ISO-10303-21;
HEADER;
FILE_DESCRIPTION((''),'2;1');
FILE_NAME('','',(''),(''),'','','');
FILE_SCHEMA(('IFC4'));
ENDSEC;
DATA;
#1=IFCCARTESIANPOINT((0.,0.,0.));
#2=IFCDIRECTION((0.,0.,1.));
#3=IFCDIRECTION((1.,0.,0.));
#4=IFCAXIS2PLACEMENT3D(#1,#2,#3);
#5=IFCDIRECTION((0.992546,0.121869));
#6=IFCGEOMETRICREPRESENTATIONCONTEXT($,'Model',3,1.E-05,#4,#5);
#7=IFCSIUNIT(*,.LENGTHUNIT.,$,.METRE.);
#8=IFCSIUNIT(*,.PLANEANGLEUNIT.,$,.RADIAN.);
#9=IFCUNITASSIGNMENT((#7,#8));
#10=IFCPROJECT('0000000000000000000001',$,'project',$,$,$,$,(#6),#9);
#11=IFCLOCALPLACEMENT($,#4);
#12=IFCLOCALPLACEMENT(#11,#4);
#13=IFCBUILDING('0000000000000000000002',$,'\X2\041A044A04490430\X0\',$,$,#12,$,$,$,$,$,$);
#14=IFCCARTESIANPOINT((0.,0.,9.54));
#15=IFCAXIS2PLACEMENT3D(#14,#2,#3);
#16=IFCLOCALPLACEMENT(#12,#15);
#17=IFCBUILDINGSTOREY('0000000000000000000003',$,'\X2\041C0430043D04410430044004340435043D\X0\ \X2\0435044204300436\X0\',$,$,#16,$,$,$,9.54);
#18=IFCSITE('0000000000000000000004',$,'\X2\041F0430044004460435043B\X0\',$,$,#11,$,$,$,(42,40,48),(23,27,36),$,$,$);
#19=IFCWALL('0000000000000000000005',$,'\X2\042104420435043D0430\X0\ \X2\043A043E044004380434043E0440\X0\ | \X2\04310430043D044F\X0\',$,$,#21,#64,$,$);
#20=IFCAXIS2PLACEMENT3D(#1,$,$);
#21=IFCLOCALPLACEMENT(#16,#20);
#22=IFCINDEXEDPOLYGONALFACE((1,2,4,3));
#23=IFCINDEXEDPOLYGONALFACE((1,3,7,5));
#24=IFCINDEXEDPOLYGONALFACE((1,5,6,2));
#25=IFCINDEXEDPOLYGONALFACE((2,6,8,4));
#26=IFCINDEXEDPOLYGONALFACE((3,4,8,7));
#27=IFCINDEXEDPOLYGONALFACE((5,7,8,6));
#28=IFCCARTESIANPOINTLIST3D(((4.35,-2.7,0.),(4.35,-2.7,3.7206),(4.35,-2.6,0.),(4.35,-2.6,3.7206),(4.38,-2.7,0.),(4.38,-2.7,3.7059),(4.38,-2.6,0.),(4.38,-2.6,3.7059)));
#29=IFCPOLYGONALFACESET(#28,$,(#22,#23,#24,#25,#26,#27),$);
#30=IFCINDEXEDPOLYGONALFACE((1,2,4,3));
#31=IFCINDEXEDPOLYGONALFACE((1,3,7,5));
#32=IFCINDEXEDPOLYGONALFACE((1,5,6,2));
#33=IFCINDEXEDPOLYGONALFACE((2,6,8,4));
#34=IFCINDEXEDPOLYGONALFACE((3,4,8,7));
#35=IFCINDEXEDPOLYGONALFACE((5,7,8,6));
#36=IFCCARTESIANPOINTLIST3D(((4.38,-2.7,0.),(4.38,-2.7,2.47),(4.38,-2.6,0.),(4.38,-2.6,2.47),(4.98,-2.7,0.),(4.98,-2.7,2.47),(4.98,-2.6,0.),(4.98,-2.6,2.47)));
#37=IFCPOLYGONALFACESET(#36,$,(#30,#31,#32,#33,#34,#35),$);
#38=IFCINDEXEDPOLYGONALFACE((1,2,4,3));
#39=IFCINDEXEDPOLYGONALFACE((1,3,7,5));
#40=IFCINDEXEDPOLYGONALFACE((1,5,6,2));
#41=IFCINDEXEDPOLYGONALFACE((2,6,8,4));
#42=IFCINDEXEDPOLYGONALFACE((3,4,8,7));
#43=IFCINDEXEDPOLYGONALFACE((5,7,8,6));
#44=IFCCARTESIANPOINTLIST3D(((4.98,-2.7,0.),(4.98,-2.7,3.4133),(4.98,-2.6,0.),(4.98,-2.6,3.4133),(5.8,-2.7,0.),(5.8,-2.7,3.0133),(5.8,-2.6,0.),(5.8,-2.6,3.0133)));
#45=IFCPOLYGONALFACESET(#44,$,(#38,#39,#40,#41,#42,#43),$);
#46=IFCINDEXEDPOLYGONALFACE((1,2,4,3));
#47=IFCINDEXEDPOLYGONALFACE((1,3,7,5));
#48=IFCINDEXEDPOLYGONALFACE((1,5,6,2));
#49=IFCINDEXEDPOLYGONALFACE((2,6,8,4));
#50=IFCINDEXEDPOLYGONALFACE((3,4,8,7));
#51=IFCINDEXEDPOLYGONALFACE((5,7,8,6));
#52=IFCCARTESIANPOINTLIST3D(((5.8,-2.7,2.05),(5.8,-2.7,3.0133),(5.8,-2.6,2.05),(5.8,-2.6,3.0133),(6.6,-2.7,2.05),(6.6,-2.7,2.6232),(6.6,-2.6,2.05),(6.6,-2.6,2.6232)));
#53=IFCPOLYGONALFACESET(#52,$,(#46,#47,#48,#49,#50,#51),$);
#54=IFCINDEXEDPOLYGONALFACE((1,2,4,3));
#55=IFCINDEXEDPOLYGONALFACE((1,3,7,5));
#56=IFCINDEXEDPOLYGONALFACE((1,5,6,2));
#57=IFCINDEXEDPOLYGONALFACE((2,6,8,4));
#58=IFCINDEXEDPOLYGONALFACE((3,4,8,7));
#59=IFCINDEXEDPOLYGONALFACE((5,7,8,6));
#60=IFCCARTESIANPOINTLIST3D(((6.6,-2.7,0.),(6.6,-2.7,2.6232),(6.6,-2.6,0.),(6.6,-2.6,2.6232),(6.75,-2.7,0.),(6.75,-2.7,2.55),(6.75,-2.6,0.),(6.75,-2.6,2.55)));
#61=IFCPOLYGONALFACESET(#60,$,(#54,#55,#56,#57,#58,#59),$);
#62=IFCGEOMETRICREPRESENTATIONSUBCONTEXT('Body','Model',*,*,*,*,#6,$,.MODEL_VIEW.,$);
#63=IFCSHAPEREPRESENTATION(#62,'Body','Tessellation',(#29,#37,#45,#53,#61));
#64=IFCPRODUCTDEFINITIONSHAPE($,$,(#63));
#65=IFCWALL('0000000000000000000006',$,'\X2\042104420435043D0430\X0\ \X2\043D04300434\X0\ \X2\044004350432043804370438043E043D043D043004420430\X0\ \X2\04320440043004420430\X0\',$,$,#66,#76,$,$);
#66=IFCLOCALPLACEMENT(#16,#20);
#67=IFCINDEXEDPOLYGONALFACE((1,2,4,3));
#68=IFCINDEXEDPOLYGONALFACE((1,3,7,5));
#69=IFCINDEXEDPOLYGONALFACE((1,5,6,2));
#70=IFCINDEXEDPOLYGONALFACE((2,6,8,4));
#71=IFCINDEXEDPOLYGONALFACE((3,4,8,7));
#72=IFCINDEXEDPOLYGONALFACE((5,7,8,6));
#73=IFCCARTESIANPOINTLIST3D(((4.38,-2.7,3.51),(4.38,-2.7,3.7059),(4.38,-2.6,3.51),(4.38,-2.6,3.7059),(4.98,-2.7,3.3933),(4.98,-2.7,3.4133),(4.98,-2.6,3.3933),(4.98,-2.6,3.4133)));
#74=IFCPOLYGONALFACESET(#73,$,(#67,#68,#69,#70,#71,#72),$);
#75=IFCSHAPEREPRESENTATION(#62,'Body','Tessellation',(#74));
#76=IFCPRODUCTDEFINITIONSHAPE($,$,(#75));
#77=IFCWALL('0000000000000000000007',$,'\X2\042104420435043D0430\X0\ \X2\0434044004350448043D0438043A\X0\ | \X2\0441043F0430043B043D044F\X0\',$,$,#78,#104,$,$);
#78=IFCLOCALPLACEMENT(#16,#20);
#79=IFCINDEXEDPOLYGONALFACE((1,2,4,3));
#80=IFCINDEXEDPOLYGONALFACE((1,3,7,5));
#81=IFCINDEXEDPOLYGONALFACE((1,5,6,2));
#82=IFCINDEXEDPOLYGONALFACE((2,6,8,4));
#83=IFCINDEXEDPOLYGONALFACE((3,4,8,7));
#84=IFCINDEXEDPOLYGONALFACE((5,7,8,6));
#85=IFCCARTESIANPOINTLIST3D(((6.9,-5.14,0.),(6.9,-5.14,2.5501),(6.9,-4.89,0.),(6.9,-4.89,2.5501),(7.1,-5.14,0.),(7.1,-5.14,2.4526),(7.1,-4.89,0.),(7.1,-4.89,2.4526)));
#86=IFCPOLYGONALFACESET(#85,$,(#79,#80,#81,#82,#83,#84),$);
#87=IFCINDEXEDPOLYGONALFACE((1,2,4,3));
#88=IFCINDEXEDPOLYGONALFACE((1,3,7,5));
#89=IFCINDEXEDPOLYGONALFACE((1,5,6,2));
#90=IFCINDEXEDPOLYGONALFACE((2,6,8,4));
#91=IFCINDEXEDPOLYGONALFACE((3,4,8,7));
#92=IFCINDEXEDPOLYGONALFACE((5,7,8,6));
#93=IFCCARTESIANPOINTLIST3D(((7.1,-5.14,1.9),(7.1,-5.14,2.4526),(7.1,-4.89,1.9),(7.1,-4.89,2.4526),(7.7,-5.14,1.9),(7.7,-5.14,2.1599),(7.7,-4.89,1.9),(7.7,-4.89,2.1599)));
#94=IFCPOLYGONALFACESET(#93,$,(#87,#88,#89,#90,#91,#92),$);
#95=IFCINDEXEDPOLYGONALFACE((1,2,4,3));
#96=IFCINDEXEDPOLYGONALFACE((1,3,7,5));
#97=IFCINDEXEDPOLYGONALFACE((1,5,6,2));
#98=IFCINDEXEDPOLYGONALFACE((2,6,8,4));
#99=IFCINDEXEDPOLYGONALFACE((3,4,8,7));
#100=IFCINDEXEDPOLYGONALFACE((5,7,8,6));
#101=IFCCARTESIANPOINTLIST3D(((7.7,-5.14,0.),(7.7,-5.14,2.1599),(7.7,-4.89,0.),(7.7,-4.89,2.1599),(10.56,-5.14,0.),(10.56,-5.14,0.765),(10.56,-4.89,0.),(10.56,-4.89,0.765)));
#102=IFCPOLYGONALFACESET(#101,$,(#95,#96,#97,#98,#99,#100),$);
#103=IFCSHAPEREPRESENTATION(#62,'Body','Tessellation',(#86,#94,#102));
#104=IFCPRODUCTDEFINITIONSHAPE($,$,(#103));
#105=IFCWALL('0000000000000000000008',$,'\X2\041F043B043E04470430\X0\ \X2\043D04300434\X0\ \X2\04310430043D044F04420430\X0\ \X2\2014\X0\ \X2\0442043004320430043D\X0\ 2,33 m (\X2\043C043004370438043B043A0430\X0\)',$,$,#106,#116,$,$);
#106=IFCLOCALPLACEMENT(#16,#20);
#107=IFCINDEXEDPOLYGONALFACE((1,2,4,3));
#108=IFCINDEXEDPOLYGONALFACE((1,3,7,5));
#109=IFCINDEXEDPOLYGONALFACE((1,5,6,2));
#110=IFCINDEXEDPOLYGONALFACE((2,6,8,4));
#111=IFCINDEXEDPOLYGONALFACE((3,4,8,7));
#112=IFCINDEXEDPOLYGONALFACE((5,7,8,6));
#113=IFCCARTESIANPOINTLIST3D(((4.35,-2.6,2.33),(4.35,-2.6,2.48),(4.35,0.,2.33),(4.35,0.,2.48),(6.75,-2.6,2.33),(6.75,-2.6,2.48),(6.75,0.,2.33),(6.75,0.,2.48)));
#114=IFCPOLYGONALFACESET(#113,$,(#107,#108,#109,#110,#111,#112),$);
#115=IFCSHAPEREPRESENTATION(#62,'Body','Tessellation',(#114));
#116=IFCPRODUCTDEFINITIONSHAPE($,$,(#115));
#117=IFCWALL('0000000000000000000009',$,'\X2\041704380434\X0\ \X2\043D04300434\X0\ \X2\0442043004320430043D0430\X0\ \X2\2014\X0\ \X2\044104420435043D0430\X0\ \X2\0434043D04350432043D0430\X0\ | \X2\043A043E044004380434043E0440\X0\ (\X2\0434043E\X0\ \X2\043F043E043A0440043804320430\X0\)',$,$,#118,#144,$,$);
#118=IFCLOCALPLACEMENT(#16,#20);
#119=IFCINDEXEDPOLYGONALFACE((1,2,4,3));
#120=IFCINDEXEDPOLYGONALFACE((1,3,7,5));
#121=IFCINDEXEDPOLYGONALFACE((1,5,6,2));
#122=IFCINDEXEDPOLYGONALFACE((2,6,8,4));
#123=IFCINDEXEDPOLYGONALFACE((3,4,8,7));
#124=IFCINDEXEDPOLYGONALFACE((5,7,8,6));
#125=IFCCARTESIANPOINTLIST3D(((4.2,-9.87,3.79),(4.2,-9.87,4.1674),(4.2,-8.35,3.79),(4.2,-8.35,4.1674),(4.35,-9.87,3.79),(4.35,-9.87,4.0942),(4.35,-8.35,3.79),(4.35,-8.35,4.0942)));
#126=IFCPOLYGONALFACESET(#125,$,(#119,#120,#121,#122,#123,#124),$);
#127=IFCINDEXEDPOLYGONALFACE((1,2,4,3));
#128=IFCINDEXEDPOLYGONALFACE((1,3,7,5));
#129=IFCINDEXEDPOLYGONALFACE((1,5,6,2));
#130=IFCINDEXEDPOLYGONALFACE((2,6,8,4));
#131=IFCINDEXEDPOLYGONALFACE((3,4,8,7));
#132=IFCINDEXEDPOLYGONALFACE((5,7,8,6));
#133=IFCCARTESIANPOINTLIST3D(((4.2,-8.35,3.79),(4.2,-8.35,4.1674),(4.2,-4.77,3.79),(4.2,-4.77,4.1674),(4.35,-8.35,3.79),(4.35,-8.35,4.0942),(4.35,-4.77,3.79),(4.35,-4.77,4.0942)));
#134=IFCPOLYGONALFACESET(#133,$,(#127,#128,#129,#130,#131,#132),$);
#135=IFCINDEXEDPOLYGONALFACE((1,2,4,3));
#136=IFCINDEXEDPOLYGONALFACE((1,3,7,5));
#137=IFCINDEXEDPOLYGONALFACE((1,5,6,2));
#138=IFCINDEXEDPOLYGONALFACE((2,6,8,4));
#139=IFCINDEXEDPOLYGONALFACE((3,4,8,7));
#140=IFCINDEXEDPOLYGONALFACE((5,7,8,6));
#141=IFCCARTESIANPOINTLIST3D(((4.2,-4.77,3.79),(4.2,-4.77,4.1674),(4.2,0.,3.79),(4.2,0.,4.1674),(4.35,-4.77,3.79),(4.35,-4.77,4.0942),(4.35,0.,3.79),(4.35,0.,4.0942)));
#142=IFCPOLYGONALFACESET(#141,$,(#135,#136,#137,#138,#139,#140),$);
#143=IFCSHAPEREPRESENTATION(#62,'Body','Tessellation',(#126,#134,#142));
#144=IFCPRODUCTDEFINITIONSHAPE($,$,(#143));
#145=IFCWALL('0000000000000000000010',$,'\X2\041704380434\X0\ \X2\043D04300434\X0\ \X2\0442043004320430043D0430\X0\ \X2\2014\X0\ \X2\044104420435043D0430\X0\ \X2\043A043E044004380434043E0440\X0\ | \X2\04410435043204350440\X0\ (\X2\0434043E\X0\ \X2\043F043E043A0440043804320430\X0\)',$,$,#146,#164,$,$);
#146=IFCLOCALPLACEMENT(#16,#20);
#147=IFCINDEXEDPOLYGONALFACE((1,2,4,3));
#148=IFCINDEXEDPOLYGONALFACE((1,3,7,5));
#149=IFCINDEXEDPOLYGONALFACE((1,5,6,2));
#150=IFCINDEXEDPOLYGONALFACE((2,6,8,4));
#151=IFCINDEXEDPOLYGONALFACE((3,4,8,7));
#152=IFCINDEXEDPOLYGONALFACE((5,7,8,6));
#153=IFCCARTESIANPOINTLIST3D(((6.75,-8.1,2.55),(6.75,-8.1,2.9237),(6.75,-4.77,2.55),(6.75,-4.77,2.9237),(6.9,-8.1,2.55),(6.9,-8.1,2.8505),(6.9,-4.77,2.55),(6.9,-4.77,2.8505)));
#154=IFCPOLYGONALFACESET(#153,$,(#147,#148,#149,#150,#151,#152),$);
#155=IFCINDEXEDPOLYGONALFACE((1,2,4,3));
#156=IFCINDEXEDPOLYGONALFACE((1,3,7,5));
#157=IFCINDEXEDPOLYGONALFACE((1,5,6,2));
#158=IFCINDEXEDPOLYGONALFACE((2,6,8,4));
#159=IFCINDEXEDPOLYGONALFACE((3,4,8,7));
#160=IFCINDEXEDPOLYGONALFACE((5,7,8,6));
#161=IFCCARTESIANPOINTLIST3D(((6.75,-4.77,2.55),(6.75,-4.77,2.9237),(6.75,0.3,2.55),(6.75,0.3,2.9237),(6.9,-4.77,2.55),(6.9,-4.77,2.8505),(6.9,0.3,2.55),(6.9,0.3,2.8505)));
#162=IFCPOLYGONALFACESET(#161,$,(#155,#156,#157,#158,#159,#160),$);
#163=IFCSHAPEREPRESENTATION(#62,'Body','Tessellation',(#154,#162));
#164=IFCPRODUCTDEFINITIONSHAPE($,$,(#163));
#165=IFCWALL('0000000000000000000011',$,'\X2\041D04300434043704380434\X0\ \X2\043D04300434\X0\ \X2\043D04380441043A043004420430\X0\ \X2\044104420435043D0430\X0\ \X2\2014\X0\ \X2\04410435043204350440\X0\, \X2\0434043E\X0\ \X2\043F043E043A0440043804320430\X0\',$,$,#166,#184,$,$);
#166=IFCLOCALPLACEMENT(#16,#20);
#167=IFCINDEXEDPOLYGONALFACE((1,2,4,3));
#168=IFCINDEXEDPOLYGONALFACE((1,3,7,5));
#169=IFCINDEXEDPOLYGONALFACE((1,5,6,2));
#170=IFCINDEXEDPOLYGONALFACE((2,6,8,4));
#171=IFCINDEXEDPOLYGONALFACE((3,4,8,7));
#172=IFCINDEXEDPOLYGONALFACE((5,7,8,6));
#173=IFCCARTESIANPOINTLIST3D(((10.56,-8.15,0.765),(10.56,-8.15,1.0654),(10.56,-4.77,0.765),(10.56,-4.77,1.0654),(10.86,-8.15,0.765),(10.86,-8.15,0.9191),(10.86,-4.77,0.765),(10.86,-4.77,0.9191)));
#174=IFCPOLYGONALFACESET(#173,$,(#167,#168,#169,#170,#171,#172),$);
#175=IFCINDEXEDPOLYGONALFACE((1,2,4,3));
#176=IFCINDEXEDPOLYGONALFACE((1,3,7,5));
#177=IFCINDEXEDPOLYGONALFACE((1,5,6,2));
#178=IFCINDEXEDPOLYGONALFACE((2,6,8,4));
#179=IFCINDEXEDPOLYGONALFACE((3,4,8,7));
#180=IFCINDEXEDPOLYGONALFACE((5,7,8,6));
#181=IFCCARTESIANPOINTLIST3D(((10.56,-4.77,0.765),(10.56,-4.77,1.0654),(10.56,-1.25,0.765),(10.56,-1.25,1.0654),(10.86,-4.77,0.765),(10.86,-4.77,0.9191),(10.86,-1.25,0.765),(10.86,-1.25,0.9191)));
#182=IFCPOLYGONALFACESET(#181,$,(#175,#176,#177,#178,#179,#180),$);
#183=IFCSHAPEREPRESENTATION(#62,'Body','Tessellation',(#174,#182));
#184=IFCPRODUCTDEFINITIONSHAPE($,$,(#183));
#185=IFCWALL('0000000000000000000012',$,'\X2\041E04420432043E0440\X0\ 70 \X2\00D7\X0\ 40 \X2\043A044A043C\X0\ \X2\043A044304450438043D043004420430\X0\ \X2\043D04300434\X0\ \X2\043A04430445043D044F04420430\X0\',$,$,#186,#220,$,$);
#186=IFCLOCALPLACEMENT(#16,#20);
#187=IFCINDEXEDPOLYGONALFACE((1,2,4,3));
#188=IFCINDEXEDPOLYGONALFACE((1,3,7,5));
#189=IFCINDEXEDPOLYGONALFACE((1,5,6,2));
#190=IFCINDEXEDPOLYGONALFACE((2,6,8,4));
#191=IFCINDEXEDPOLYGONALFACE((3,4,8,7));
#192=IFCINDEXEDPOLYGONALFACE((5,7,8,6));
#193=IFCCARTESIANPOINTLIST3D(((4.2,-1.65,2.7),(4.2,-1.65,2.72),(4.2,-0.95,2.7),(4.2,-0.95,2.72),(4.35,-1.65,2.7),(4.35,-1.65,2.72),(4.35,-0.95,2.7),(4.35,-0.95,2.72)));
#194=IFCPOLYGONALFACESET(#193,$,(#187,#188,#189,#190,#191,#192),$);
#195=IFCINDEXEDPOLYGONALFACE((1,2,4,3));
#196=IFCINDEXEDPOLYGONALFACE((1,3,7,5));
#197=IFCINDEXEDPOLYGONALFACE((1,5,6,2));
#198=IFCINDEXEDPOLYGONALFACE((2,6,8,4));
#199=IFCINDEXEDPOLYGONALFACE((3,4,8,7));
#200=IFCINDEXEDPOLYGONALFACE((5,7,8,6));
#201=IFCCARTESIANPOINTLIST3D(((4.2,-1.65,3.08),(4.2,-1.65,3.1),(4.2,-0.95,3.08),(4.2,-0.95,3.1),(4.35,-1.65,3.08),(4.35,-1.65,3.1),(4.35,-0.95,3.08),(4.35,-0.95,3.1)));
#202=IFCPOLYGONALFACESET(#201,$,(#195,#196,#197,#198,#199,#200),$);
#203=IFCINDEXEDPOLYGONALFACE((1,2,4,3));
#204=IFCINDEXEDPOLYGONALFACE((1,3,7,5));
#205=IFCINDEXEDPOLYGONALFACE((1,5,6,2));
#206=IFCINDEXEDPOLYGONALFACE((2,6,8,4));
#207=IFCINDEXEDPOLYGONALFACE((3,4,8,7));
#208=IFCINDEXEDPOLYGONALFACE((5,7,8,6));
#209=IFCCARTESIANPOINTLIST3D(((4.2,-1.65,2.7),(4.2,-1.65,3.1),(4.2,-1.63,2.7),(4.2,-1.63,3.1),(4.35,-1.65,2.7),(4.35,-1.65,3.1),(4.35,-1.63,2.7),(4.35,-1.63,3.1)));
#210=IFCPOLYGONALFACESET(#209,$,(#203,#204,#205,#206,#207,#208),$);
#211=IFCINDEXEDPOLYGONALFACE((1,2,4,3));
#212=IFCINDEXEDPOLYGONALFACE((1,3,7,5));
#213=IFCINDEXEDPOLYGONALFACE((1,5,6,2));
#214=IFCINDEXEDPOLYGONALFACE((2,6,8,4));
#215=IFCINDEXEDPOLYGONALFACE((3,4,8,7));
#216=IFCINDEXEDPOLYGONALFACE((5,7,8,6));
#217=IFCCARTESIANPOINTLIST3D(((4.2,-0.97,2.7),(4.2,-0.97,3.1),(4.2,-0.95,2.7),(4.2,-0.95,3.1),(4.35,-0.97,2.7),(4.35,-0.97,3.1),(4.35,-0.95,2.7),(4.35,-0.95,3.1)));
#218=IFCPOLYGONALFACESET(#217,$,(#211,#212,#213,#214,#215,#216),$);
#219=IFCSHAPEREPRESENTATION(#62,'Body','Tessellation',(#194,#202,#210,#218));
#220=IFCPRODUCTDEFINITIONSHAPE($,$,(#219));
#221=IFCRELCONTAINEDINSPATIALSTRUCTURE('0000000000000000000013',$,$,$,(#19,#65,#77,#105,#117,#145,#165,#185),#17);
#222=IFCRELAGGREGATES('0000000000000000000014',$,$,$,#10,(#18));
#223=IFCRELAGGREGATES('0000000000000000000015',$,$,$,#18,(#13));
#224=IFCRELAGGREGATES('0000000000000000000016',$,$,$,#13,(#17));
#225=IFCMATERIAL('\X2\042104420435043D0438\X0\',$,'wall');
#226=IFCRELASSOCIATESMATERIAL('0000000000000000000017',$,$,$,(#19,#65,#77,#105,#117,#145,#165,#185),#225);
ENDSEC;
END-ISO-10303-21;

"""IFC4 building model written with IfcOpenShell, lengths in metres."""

from ifc_helpers import new_model, si_unit, direction, frame, origin_with_axes, place, context, subcontext, project, spatial, polyline, outline, extrude, material, element, save


model = new_model("IFC4")

# Units and contexts
model_context = context("Model", 3, precision=1e-05, world=origin_with_axes(), true_north=direction((0.992546, 0.121869)))
body_context = subcontext(model_context, "Body", "Model", "MODEL_VIEW")
ifc_project = project(units=[si_unit("LENGTHUNIT", "METRE"), si_unit("PLANEANGLEUNIT", "RADIAN")], contexts=[model_context])

# Site, building, storey
site_placement = place(None, origin_with_axes())
site = spatial("IfcSite", under=ifc_project, at=site_placement, Name="Парцел", RefLatitude=(42, 40, 48), RefLongitude=(23, 27, 36))
building_placement = place(site_placement, origin_with_axes())
building = spatial("IfcBuilding", under=site, at=building_placement, Name="Къща")
storey_placement = place(building_placement, frame((0.0, 0.0, 9.54), z_axis=(0.0, 0.0, 1.0), x_axis=(1.0, 0.0, 0.0)))
storey = spatial("IfcBuildingStorey", under=building, at=storey_placement, Name="Мансарден етаж", Elevation=9.54)

# Walls
ifc_material_1 = material(Name="Стени", Category="wall")
wall_1_placement = place(storey_placement, origin_with_axes())
element("IfcWall", 1, at=wall_1_placement, inside=storey, material=ifc_material_1, Name="Стена коридор | баня", context=body_context, shape_type="SweptSolid", body=[
    extrude(outline(polyline([(4.35, 0.0), (4.38, 0.0), (4.38, -3.7059), (4.35, -3.7206), (4.35, 0.0)])), frame((0.0, -2.7, 0.0), z_axis=(0.0, 1.0, 0.0), x_axis=(1.0, 0.0, 0.0)), (0.0, 0.0, 1.0), 0.1),
    extrude(outline(polyline([(4.38, 0.0), (4.98, 0.0), (4.98, -2.47), (4.38, -2.47), (4.38, 0.0)])), frame((0.0, -2.7, 0.0), z_axis=(0.0, 1.0, 0.0), x_axis=(1.0, 0.0, 0.0)), (0.0, 0.0, 1.0), 0.1),
    extrude(outline(polyline([(4.98, 0.0), (5.8, 0.0), (5.8, -3.0133), (4.98, -3.4133), (4.98, 0.0)])), frame((0.0, -2.7, 0.0), z_axis=(0.0, 1.0, 0.0), x_axis=(1.0, 0.0, 0.0)), (0.0, 0.0, 1.0), 0.1),
    extrude(outline(polyline([(5.8, -2.05), (6.6, -2.05), (6.6, -2.6232), (5.8, -3.0133), (5.8, -2.05)])), frame((0.0, -2.7, 0.0), z_axis=(0.0, 1.0, 0.0), x_axis=(1.0, 0.0, 0.0)), (0.0, 0.0, 1.0), 0.1),
    extrude(outline(polyline([(6.6, 0.0), (6.75, 0.0), (6.75, -2.55), (6.6, -2.6232), (6.6, 0.0)])), frame((0.0, -2.7, 0.0), z_axis=(0.0, 1.0, 0.0), x_axis=(1.0, 0.0, 0.0)), (0.0, 0.0, 1.0), 0.1),
])
wall_2_placement = place(storey_placement, origin_with_axes())
element("IfcWall", 2, at=wall_2_placement, inside=storey, material=ifc_material_1, Name="Стена над ревизионната врата", context=body_context, shape_type="SweptSolid", body=[
    extrude(outline(polyline([(4.38, -3.51), (4.98, -3.3933), (4.98, -3.4133), (4.38, -3.7059), (4.38, -3.51)])), frame((0.0, -2.7, 0.0), z_axis=(0.0, 1.0, 0.0), x_axis=(1.0, 0.0, 0.0)), (0.0, 0.0, 1.0), 0.1),
])
wall_3_placement = place(storey_placement, origin_with_axes())
element("IfcWall", 3, at=wall_3_placement, inside=storey, material=ifc_material_1, Name="Стена дрешник | спалня", context=body_context, shape_type="SweptSolid", body=[
    extrude(outline(polyline([(6.9, 0.0), (7.1, 0.0), (7.1, -2.4526), (6.9, -2.5501), (6.9, 0.0)])), frame((0.0, -5.14, 0.0), z_axis=(0.0, 1.0, 0.0), x_axis=(1.0, 0.0, 0.0)), (0.0, 0.0, 1.0), 0.25),
    extrude(outline(polyline([(7.1, -1.9), (7.7, -1.9), (7.7, -2.1599), (7.1, -2.4526), (7.1, -1.9)])), frame((0.0, -5.14, 0.0), z_axis=(0.0, 1.0, 0.0), x_axis=(1.0, 0.0, 0.0)), (0.0, 0.0, 1.0), 0.25),
    extrude(outline(polyline([(7.7, 0.0), (10.56, 0.0), (10.56, -0.765), (7.7, -2.1599), (7.7, 0.0)])), frame((0.0, -5.14, 0.0), z_axis=(0.0, 1.0, 0.0), x_axis=(1.0, 0.0, 0.0)), (0.0, 0.0, 1.0), 0.25),
])
wall_4_placement = place(storey_placement, origin_with_axes())
element("IfcWall", 4, at=wall_4_placement, inside=storey, material=ifc_material_1, Name="Плоча над банята — таван 2,33 m (мазилка)", context=body_context, shape_type="SweptSolid", body=[
    extrude(outline(polyline([(4.35, -2.33), (6.75, -2.33), (6.75, -2.48), (4.35, -2.48), (4.35, -2.33)])), frame((0.0, -2.6, 0.0), z_axis=(0.0, 1.0, 0.0), x_axis=(1.0, 0.0, 0.0)), (0.0, 0.0, 1.0), 2.6),
])
wall_5_placement = place(storey_placement, origin_with_axes())
element("IfcWall", 5, at=wall_5_placement, inside=storey, material=ifc_material_1, Name="Зид над тавана — стена дневна | коридор (до покрива)", context=body_context, shape_type="SweptSolid", body=[
    extrude(outline(polyline([(4.2, -3.79), (4.35, -3.79), (4.35, -4.0942), (4.2, -4.1674), (4.2, -3.79)])), frame((0.0, -9.87, 0.0), z_axis=(0.0, 1.0, 0.0), x_axis=(1.0, 0.0, 0.0)), (0.0, 0.0, 1.0), 1.52),
    extrude(outline(polyline([(4.2, -3.79), (4.35, -3.79), (4.35, -4.0942), (4.2, -4.1674), (4.2, -3.79)])), frame((0.0, -8.35, 0.0), z_axis=(0.0, 1.0, 0.0), x_axis=(1.0, 0.0, 0.0)), (0.0, 0.0, 1.0), 3.58),
    extrude(outline(polyline([(4.2, -3.79), (4.35, -3.79), (4.35, -4.0942), (4.2, -4.1674), (4.2, -3.79)])), frame((0.0, -4.77, 0.0), z_axis=(0.0, 1.0, 0.0), x_axis=(1.0, 0.0, 0.0)), (0.0, 0.0, 1.0), 4.77),
])
wall_6_placement = place(storey_placement, origin_with_axes())
element("IfcWall", 6, at=wall_6_placement, inside=storey, material=ifc_material_1, Name="Зид над тавана — стена коридор | север (до покрива)", context=body_context, shape_type="SweptSolid", body=[
    extrude(outline(polyline([(6.75, -2.55), (6.9, -2.55), (6.9, -2.8505), (6.75, -2.9237), (6.75, -2.55)])), frame((0.0, -8.1, 0.0), z_axis=(0.0, 1.0, 0.0), x_axis=(1.0, 0.0, 0.0)), (0.0, 0.0, 1.0), 3.33),
    extrude(outline(polyline([(6.75, -2.55), (6.9, -2.55), (6.9, -2.8505), (6.75, -2.9237), (6.75, -2.55)])), frame((0.0, -4.77, 0.0), z_axis=(0.0, 1.0, 0.0), x_axis=(1.0, 0.0, 0.0)), (0.0, 0.0, 1.0), 5.07),
])
wall_7_placement = place(storey_placement, origin_with_axes())
element("IfcWall", 7, at=wall_7_placement, inside=storey, material=ifc_material_1, Name="Надзид над ниската стена — север, до покрива", context=body_context, shape_type="SweptSolid", body=[
    extrude(outline(polyline([(10.56, -0.765), (10.86, -0.765), (10.86, -0.9191), (10.56, -1.0654), (10.56, -0.765)])), frame((0.0, -8.15, 0.0), z_axis=(0.0, 1.0, 0.0), x_axis=(1.0, 0.0, 0.0)), (0.0, 0.0, 1.0), 3.38),
    extrude(outline(polyline([(10.56, -0.765), (10.86, -0.765), (10.86, -0.9191), (10.56, -1.0654), (10.56, -0.765)])), frame((0.0, -4.77, 0.0), z_axis=(0.0, 1.0, 0.0), x_axis=(1.0, 0.0, 0.0)), (0.0, 0.0, 1.0), 3.52),
])
wall_8_placement = place(storey_placement, origin_with_axes())
element("IfcWall", 8, at=wall_8_placement, inside=storey, material=ifc_material_1, Name="Отвор 70 × 40 към кухината над кухнята", context=body_context, shape_type="SweptSolid", body=[
    extrude(outline(polyline([(4.2, -2.7), (4.35, -2.7), (4.35, -2.72), (4.2, -2.72), (4.2, -2.7)])), frame((0.0, -1.65, 0.0), z_axis=(0.0, 1.0, 0.0), x_axis=(1.0, 0.0, 0.0)), (0.0, 0.0, 1.0), 0.7),
    extrude(outline(polyline([(4.2, -3.08), (4.35, -3.08), (4.35, -3.1), (4.2, -3.1), (4.2, -3.08)])), frame((0.0, -1.65, 0.0), z_axis=(0.0, 1.0, 0.0), x_axis=(1.0, 0.0, 0.0)), (0.0, 0.0, 1.0), 0.7),
    extrude(outline(polyline([(4.2, -2.7), (4.35, -2.7), (4.35, -3.1), (4.2, -3.1), (4.2, -2.7)])), frame((0.0, -1.65, 0.0), z_axis=(0.0, 1.0, 0.0), x_axis=(1.0, 0.0, 0.0)), (0.0, 0.0, 1.0), 0.02),
    extrude(outline(polyline([(4.2, -2.7), (4.35, -2.7), (4.35, -3.1), (4.2, -3.1), (4.2, -2.7)])), frame((0.0, -0.97, 0.0), z_axis=(0.0, 1.0, 0.0), x_axis=(1.0, 0.0, 0.0)), (0.0, 0.0, 1.0), 0.02),
])

save(model, "model.ifc")
